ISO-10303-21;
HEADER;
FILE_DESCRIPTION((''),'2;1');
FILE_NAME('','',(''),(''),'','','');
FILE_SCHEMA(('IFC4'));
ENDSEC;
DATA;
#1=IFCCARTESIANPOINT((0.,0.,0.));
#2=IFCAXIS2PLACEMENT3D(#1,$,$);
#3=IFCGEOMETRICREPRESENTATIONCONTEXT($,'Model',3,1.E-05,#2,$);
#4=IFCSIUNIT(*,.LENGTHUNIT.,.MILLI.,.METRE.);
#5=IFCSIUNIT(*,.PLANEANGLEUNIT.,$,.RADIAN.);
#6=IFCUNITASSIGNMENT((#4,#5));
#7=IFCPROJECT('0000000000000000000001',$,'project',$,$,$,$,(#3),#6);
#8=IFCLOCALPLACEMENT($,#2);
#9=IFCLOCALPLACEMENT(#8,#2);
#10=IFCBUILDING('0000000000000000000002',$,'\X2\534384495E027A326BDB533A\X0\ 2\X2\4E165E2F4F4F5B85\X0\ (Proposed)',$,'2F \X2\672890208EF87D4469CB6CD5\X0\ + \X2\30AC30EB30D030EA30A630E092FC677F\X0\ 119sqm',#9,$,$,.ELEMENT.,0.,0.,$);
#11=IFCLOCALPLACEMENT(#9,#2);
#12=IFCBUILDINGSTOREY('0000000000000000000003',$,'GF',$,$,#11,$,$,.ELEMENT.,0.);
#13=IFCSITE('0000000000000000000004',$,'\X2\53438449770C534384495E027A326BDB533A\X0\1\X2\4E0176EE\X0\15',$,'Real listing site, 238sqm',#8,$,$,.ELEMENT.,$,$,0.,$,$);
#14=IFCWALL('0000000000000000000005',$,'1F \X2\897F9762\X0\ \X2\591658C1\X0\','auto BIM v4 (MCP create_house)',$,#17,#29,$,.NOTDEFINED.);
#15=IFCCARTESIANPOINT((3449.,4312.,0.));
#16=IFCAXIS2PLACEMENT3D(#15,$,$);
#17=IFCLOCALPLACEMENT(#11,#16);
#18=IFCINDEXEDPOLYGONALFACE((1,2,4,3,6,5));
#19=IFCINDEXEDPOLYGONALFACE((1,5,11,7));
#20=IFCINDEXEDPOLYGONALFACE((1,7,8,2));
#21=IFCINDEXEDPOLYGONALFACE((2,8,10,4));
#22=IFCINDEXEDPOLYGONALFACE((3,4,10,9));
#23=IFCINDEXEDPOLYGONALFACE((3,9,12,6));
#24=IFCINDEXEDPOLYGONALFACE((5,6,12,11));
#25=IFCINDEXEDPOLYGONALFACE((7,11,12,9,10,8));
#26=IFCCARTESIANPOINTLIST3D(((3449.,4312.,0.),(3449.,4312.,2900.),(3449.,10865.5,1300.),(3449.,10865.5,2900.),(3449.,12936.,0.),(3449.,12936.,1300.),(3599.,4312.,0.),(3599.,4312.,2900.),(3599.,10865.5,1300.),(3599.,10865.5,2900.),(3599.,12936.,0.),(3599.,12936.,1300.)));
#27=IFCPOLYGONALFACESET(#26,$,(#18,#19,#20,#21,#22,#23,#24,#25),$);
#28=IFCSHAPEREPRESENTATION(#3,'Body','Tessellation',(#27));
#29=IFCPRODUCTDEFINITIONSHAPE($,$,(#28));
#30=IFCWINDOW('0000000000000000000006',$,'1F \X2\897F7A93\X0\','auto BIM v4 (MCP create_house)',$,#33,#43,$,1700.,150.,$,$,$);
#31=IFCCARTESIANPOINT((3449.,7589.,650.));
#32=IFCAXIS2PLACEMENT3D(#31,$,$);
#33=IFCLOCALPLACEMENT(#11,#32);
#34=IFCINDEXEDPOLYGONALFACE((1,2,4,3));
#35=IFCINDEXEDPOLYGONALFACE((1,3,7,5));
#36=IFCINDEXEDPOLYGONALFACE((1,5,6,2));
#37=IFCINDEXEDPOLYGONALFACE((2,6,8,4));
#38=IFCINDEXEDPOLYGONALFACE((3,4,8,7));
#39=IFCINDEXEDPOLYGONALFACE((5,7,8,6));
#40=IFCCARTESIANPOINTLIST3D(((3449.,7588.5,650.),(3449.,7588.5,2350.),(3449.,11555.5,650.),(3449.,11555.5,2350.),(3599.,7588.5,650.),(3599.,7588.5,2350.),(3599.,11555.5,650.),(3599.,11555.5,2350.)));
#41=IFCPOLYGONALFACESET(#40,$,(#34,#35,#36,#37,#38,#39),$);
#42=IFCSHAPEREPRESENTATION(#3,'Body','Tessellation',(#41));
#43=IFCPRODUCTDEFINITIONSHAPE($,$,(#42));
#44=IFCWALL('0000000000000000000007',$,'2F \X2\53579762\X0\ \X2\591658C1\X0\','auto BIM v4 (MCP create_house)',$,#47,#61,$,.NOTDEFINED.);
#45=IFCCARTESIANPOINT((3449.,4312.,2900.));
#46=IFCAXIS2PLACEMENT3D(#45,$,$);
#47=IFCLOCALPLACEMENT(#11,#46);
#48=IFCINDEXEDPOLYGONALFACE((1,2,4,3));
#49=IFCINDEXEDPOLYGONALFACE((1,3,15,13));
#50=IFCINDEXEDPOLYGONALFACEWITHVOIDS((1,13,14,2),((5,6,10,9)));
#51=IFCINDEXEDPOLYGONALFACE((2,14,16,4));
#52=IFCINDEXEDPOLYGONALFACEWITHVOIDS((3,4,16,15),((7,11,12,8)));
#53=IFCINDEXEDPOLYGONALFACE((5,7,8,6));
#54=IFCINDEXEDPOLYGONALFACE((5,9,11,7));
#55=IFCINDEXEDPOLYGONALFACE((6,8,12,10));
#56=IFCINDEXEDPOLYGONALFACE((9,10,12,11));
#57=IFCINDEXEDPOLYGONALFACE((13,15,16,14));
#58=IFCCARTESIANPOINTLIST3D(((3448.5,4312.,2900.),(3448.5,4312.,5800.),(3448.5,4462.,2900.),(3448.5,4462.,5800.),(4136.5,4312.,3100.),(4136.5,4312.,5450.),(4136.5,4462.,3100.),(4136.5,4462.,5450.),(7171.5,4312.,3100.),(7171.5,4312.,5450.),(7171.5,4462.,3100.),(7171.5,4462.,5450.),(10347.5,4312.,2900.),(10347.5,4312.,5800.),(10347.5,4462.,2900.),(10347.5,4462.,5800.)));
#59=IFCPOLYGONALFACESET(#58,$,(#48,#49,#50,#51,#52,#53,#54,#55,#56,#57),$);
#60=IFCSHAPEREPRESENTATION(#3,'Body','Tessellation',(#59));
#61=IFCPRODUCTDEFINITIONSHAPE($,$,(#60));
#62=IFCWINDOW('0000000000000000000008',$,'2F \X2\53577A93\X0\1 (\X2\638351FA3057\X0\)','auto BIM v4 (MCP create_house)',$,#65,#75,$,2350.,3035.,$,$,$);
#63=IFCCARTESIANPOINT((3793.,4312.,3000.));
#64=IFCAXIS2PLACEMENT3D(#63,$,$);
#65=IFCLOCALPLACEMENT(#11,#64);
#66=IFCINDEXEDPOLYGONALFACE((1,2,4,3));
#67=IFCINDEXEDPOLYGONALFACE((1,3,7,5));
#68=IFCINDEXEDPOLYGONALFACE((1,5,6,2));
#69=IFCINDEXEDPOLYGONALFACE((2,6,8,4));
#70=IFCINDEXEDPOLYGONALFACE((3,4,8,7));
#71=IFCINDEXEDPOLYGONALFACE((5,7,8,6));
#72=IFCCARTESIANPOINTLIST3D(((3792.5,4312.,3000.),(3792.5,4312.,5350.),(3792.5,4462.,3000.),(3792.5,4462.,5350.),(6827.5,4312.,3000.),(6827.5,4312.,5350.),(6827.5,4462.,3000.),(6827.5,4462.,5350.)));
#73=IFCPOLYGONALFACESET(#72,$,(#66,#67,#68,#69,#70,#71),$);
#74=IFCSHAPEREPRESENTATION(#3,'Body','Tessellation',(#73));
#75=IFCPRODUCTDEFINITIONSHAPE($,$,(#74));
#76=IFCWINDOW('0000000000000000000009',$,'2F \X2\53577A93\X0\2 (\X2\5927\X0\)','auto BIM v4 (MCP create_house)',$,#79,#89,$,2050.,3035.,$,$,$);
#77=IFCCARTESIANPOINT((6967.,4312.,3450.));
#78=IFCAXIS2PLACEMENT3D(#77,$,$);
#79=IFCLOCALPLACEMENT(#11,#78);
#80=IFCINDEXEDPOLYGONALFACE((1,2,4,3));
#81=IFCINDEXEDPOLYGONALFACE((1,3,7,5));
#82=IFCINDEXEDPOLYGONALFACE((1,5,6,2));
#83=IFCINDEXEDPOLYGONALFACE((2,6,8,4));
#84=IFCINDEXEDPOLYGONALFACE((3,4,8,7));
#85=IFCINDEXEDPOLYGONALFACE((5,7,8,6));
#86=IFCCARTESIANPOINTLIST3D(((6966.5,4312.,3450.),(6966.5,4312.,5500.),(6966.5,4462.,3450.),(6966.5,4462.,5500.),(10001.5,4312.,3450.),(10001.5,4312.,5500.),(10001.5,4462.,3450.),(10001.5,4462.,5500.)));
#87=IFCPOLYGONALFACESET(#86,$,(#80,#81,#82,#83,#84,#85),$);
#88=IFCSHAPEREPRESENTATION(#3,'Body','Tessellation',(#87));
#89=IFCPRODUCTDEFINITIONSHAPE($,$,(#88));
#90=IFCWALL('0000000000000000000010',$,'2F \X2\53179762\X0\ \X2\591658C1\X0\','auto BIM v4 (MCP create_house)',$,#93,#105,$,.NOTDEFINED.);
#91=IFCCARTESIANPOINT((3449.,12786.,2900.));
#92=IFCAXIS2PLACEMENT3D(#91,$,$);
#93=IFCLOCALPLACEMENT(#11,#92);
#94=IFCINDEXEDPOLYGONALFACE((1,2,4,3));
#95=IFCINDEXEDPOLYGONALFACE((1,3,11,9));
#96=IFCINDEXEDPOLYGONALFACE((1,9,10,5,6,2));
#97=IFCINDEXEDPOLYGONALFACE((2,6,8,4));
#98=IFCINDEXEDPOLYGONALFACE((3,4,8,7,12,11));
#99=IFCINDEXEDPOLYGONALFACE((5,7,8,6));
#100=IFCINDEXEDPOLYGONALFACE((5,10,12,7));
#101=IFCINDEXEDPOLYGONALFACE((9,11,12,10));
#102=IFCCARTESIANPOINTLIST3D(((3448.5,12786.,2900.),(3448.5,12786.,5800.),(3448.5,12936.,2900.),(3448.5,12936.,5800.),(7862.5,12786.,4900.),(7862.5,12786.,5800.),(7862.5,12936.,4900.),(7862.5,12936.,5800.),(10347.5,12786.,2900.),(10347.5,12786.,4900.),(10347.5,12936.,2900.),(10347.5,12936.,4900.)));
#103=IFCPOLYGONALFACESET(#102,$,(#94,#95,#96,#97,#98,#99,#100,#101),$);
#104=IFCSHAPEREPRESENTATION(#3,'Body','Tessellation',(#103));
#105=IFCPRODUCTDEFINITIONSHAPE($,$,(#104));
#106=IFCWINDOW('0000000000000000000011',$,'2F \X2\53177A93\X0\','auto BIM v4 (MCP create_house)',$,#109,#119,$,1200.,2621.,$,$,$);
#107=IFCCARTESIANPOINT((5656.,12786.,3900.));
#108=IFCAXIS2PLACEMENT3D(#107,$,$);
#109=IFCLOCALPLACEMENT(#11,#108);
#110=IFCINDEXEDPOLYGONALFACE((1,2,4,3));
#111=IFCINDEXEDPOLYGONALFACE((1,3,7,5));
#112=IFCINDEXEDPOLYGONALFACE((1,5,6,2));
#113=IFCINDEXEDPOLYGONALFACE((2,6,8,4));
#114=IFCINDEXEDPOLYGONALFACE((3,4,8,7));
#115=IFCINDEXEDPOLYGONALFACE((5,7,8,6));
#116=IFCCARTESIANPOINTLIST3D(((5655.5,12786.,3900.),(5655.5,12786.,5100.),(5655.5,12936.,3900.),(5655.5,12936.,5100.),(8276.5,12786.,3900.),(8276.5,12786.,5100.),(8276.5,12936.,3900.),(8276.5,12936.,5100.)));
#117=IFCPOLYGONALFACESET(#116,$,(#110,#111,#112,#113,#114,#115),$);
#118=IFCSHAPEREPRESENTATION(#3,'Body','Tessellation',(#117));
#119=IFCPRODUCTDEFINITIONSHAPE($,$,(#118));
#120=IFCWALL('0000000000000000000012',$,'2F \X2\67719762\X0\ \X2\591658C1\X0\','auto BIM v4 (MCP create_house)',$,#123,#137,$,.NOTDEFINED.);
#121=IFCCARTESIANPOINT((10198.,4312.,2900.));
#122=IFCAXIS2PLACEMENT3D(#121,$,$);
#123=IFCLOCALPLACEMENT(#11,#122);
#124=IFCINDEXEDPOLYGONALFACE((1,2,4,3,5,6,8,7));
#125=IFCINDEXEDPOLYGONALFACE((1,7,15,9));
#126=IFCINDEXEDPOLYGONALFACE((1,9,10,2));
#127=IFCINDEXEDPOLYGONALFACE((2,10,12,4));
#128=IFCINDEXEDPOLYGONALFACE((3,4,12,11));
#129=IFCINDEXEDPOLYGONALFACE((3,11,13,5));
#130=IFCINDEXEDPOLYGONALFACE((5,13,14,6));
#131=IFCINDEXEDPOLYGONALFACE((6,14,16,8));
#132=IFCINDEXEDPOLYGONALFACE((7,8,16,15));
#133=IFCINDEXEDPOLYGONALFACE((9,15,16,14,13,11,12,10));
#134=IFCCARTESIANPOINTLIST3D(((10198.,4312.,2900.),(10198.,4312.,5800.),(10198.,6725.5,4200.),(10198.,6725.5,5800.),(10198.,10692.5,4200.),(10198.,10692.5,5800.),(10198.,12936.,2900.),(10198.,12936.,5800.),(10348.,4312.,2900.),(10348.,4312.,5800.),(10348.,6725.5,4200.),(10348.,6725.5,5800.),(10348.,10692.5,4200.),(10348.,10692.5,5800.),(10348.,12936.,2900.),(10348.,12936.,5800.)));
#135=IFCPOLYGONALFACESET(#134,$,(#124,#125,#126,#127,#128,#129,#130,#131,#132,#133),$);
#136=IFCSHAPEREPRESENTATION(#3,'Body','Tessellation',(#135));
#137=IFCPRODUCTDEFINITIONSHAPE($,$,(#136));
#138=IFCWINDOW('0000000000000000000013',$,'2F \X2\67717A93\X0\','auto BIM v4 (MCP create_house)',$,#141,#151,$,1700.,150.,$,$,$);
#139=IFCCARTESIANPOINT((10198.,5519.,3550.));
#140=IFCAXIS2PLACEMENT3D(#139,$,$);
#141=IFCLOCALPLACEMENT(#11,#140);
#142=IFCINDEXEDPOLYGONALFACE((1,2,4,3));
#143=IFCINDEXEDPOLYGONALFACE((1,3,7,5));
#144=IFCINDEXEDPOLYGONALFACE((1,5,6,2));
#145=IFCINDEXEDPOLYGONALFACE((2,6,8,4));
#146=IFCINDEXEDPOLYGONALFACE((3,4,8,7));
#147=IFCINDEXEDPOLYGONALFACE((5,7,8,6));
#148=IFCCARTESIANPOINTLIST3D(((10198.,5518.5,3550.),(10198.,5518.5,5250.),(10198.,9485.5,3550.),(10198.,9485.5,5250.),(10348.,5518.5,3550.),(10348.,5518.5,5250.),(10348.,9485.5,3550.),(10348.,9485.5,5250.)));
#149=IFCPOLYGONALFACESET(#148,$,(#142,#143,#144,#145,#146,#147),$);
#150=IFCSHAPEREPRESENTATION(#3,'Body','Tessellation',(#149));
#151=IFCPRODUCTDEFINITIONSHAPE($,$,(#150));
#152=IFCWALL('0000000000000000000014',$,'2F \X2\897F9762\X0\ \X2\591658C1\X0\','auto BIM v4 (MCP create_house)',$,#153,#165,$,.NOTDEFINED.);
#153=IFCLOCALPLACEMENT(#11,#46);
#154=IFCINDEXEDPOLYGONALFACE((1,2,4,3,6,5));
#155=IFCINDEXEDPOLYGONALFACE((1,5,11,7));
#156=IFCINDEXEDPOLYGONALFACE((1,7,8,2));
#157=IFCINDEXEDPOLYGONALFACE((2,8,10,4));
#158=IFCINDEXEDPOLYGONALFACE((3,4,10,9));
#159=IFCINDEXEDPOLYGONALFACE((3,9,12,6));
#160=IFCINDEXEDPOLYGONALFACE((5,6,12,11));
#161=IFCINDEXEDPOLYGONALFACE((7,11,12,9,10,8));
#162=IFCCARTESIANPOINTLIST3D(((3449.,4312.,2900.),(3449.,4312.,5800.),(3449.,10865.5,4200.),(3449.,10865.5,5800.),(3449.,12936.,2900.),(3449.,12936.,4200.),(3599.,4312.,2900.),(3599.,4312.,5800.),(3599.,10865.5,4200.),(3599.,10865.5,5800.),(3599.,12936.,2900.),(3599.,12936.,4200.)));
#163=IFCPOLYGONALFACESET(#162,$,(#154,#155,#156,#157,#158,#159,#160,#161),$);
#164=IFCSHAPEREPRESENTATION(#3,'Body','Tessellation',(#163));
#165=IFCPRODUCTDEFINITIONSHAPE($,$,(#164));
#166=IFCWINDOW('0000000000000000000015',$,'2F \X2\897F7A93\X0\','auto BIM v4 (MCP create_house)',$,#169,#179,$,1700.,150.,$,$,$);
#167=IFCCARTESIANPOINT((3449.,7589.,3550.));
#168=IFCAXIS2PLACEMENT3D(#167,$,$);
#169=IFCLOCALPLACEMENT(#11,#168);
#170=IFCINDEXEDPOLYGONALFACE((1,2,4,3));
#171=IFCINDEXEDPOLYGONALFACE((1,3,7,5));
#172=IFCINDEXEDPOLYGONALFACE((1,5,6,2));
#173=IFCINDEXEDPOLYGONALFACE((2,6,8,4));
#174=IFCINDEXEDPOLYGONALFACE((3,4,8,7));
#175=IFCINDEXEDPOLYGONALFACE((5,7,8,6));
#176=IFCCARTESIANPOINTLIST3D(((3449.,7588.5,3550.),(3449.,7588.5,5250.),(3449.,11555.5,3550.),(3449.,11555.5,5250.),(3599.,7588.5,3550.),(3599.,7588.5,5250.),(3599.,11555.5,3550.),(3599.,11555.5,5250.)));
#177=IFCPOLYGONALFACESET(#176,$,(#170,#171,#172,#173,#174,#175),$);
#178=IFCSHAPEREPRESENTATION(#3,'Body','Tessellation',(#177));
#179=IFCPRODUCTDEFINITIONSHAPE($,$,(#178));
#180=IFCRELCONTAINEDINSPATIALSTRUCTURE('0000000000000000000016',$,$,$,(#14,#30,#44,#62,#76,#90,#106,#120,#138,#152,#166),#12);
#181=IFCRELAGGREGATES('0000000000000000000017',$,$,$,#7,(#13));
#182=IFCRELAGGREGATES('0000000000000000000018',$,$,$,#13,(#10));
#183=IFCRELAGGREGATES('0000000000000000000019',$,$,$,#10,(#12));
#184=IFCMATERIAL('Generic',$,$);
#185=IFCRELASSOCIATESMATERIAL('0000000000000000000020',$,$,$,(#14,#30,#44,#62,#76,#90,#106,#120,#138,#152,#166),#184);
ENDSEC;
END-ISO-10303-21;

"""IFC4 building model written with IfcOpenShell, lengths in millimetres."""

from ifc_helpers import new_model, si_unit, frame, frame_2d, origin, place, context, project, spatial, rectangle, extrude, material, element, fill, save


model = new_model("IFC4")

# Units and contexts
model_context = context("Model", 3, precision=1e-05, world=origin())
ifc_project = project(units=[si_unit("LENGTHUNIT", "METRE", prefix="MILLI"), si_unit("PLANEANGLEUNIT", "RADIAN")], contexts=[model_context])

# Site, building, storey
site_placement = place(None, origin())
site = spatial("IfcSite", under=ifc_project, at=site_placement, Name="千葉県千葉市稲毛区1丁目15", ObjectType="Real listing site, 238sqm", CompositionType="ELEMENT", RefElevation=0.0)
building_placement = place(site_placement, origin())
building = spatial("IfcBuilding", under=site, at=building_placement, Name="千葉市稲毛区 2世帯住宅 (Proposed)", ObjectType="2F 木造軸組構法 + ガルバリウム鋼板 119sqm", CompositionType="ELEMENT", ElevationOfRefHeight=0.0, ElevationOfTerrain=0.0)
storey_placement = place(building_placement, origin())
storey = spatial("IfcBuildingStorey", under=building, at=storey_placement, Name="GF", CompositionType="ELEMENT", Elevation=0.0)

# Shared definitions
ifc_material = material(Name="Generic")

# Wall, opening, window
wall_1_placement = place(storey_placement, frame((3449.0, 4312.0, 0.0)))
wall_1 = element("IfcWall", 1, at=wall_1_placement, inside=storey, material=ifc_material, Name="1F 西面 外壁", Description="auto BIM v4 (MCP create_house)", PredefinedType="NOTDEFINED", context=model_context, shape_type="SweptSolid", body=[
    extrude(rectangle(XDim=150.0, YDim=8624.0, at=frame_2d((75.0, 4312.0))), frame((3449.0, 4312.0, 0.0)), (0.0, 0.0, 1.0), 2900.0),
])
opening_1_placement = place(storey_placement, frame((3449.0, 7589.0, 650.0)))
opening_1 = element("IfcOpeningElement", 2, at=opening_1_placement, cuts=wall_1, PredefinedType="NOTDEFINED", context=model_context, shape_type="SweptSolid", body=[
    extrude(rectangle(XDim=150.0, YDim=3967.0, at=frame_2d((75.0, 1983.0))), frame((3449.0, 7589.0, 650.0)), (0.0, 0.0, 1.0), 1700.0),
])
window_1_placement = place(storey_placement, frame((3449.0, 7589.0, 650.0)))
window_1 = element("IfcWindow", 3, at=window_1_placement, inside=storey, material=ifc_material, Name="1F 西窓", Description="auto BIM v4 (MCP create_house)", OverallHeight=1700.0, OverallWidth=150.0, context=model_context, shape_type="SweptSolid", body=[
    extrude(rectangle(XDim=150.0, YDim=3967.0, at=frame_2d((75.0, 1983.0))), frame((3449.0, 7589.0, 650.0)), (0.0, 0.0, 1.0), 1700.0),
])
fill(opening_1, window_1)

# Wall, openings, windows
wall_2_placement = place(storey_placement, frame((3449.0, 4312.0, 2900.0)))
wall_2 = element("IfcWall", 4, at=wall_2_placement, inside=storey, material=ifc_material, Name="2F 南面 外壁", Description="auto BIM v4 (MCP create_house)", PredefinedType="NOTDEFINED", context=model_context, shape_type="SweptSolid", body=[
    extrude(rectangle(XDim=6899.0, YDim=150.0, at=frame_2d((3449.0, 75.0))), frame((3449.0, 4312.0, 2900.0)), (0.0, 0.0, 1.0), 2900.0),
])
opening_2_placement = place(storey_placement, frame((3793.0, 4312.0, 3000.0)))
opening_2 = element("IfcOpeningElement", 5, at=opening_2_placement, cuts=wall_2, PredefinedType="NOTDEFINED", context=model_context, shape_type="SweptSolid", body=[
    extrude(rectangle(XDim=3035.0, YDim=150.0, at=frame_2d((1517.0, 75.0))), frame((3793.0, 4312.0, 3000.0)), (0.0, 0.0, 1.0), 2350.0),
])
opening_3_placement = place(storey_placement, frame((6967.0, 4312.0, 3450.0)))
opening_3 = element("IfcOpeningElement", 6, at=opening_3_placement, cuts=wall_2, PredefinedType="NOTDEFINED", context=model_context, shape_type="SweptSolid", body=[
    extrude(rectangle(XDim=3035.0, YDim=150.0, at=frame_2d((1517.0, 75.0))), frame((6967.0, 4312.0, 3450.0)), (0.0, 0.0, 1.0), 2050.0),
])
window_2_placement = place(storey_placement, frame((3793.0, 4312.0, 3000.0)))
window_2 = element("IfcWindow", 7, at=window_2_placement, inside=storey, material=ifc_material, Name="2F 南窓1 (掃出し)", Description="auto BIM v4 (MCP create_house)", OverallHeight=2350.0, OverallWidth=3035.0, context=model_context, shape_type="SweptSolid", body=[
    extrude(rectangle(XDim=3035.0, YDim=150.0, at=frame_2d((1517.0, 75.0))), frame((3793.0, 4312.0, 3000.0)), (0.0, 0.0, 1.0), 2350.0),
])
fill(opening_2, window_2)
window_3_placement = place(storey_placement, frame((6967.0, 4312.0, 3450.0)))
window_3 = element("IfcWindow", 8, at=window_3_placement, inside=storey, material=ifc_material, Name="2F 南窓2 (大)", Description="auto BIM v4 (MCP create_house)", OverallHeight=2050.0, OverallWidth=3035.0, context=model_context, shape_type="SweptSolid", body=[
    extrude(rectangle(XDim=3035.0, YDim=150.0, at=frame_2d((1517.0, 75.0))), frame((6967.0, 4312.0, 3450.0)), (0.0, 0.0, 1.0), 2050.0),
])
fill(opening_3, window_3)

# Walls, openings, windows
wall_3_placement = place(storey_placement, frame((3449.0, 12786.0, 2900.0)))
wall_3 = element("IfcWall", 9, at=wall_3_placement, inside=storey, material=ifc_material, Name="2F 北面 外壁", Description="auto BIM v4 (MCP create_house)", PredefinedType="NOTDEFINED", context=model_context, shape_type="SweptSolid", body=[
    extrude(rectangle(XDim=6899.0, YDim=150.0, at=frame_2d((3449.0, 75.0))), frame((3449.0, 12786.0, 2900.0)), (0.0, 0.0, 1.0), 2900.0),
])
opening_4_placement = place(storey_placement, frame((5656.0, 12786.0, 3900.0)))
opening_4 = element("IfcOpeningElement", 10, at=opening_4_placement, cuts=wall_3, PredefinedType="NOTDEFINED", context=model_context, shape_type="SweptSolid", body=[
    extrude(rectangle(XDim=2621.0, YDim=150.0, at=frame_2d((1310.0, 75.0))), frame((5656.0, 12786.0, 3900.0)), (0.0, 0.0, 1.0), 1200.0),
])
window_4_placement = place(storey_placement, frame((5656.0, 12786.0, 3900.0)))
window_4 = element("IfcWindow", 11, at=window_4_placement, inside=storey, material=ifc_material, Name="2F 北窓", Description="auto BIM v4 (MCP create_house)", OverallHeight=1200.0, OverallWidth=2621.0, context=model_context, shape_type="SweptSolid", body=[
    extrude(rectangle(XDim=2621.0, YDim=150.0, at=frame_2d((1310.0, 75.0))), frame((5656.0, 12786.0, 3900.0)), (0.0, 0.0, 1.0), 1200.0),
])
fill(opening_4, window_4)
wall_4_placement = place(storey_placement, frame((10198.0, 4312.0, 2900.0)))
wall_4 = element("IfcWall", 12, at=wall_4_placement, inside=storey, material=ifc_material, Name="2F 東面 外壁", Description="auto BIM v4 (MCP create_house)", PredefinedType="NOTDEFINED", context=model_context, shape_type="SweptSolid", body=[
    extrude(rectangle(XDim=150.0, YDim=8624.0, at=frame_2d((75.0, 4312.0))), frame((10198.0, 4312.0, 2900.0)), (0.0, 0.0, 1.0), 2900.0),
])
opening_5_placement = place(storey_placement, frame((10198.0, 5519.0, 3550.0)))
opening_5 = element("IfcOpeningElement", 13, at=opening_5_placement, cuts=wall_4, PredefinedType="NOTDEFINED", context=model_context, shape_type="SweptSolid", body=[
    extrude(rectangle(XDim=150.0, YDim=3967.0, at=frame_2d((75.0, 1983.0))), frame((10198.0, 5519.0, 3550.0)), (0.0, 0.0, 1.0), 1700.0),
])
window_5_placement = place(storey_placement, frame((10198.0, 5519.0, 3550.0)))
window_5 = element("IfcWindow", 14, at=window_5_placement, inside=storey, material=ifc_material, Name="2F 東窓", Description="auto BIM v4 (MCP create_house)", OverallHeight=1700.0, OverallWidth=150.0, context=model_context, shape_type="SweptSolid", body=[
    extrude(rectangle(XDim=150.0, YDim=3967.0, at=frame_2d((75.0, 1983.0))), frame((10198.0, 5519.0, 3550.0)), (0.0, 0.0, 1.0), 1700.0),
])
fill(opening_5, window_5)
wall_5_placement = place(storey_placement, frame((3449.0, 4312.0, 2900.0)))
wall_5 = element("IfcWall", 15, at=wall_5_placement, inside=storey, material=ifc_material, Name="2F 西面 外壁", Description="auto BIM v4 (MCP create_house)", PredefinedType="NOTDEFINED", context=model_context, shape_type="SweptSolid", body=[
    extrude(rectangle(XDim=150.0, YDim=8624.0, at=frame_2d((75.0, 4312.0))), frame((3449.0, 4312.0, 2900.0)), (0.0, 0.0, 1.0), 2900.0),
])
opening_6_placement = place(storey_placement, frame((3449.0, 7589.0, 3550.0)))
opening_6 = element("IfcOpeningElement", 16, at=opening_6_placement, cuts=wall_5, PredefinedType="NOTDEFINED", context=model_context, shape_type="SweptSolid", body=[
    extrude(rectangle(XDim=150.0, YDim=3967.0, at=frame_2d((75.0, 1983.0))), frame((3449.0, 7589.0, 3550.0)), (0.0, 0.0, 1.0), 1700.0),
])
window_6_placement = place(storey_placement, frame((3449.0, 7589.0, 3550.0)))
window_6 = element("IfcWindow", 17, at=window_6_placement, inside=storey, material=ifc_material, Name="2F 西窓", Description="auto BIM v4 (MCP create_house)", OverallHeight=1700.0, OverallWidth=150.0, context=model_context, shape_type="SweptSolid", body=[
    extrude(rectangle(XDim=150.0, YDim=3967.0, at=frame_2d((75.0, 1983.0))), frame((3449.0, 7589.0, 3550.0)), (0.0, 0.0, 1.0), 1700.0),
])
fill(opening_6, window_6)

save(model, "model.ifc")
